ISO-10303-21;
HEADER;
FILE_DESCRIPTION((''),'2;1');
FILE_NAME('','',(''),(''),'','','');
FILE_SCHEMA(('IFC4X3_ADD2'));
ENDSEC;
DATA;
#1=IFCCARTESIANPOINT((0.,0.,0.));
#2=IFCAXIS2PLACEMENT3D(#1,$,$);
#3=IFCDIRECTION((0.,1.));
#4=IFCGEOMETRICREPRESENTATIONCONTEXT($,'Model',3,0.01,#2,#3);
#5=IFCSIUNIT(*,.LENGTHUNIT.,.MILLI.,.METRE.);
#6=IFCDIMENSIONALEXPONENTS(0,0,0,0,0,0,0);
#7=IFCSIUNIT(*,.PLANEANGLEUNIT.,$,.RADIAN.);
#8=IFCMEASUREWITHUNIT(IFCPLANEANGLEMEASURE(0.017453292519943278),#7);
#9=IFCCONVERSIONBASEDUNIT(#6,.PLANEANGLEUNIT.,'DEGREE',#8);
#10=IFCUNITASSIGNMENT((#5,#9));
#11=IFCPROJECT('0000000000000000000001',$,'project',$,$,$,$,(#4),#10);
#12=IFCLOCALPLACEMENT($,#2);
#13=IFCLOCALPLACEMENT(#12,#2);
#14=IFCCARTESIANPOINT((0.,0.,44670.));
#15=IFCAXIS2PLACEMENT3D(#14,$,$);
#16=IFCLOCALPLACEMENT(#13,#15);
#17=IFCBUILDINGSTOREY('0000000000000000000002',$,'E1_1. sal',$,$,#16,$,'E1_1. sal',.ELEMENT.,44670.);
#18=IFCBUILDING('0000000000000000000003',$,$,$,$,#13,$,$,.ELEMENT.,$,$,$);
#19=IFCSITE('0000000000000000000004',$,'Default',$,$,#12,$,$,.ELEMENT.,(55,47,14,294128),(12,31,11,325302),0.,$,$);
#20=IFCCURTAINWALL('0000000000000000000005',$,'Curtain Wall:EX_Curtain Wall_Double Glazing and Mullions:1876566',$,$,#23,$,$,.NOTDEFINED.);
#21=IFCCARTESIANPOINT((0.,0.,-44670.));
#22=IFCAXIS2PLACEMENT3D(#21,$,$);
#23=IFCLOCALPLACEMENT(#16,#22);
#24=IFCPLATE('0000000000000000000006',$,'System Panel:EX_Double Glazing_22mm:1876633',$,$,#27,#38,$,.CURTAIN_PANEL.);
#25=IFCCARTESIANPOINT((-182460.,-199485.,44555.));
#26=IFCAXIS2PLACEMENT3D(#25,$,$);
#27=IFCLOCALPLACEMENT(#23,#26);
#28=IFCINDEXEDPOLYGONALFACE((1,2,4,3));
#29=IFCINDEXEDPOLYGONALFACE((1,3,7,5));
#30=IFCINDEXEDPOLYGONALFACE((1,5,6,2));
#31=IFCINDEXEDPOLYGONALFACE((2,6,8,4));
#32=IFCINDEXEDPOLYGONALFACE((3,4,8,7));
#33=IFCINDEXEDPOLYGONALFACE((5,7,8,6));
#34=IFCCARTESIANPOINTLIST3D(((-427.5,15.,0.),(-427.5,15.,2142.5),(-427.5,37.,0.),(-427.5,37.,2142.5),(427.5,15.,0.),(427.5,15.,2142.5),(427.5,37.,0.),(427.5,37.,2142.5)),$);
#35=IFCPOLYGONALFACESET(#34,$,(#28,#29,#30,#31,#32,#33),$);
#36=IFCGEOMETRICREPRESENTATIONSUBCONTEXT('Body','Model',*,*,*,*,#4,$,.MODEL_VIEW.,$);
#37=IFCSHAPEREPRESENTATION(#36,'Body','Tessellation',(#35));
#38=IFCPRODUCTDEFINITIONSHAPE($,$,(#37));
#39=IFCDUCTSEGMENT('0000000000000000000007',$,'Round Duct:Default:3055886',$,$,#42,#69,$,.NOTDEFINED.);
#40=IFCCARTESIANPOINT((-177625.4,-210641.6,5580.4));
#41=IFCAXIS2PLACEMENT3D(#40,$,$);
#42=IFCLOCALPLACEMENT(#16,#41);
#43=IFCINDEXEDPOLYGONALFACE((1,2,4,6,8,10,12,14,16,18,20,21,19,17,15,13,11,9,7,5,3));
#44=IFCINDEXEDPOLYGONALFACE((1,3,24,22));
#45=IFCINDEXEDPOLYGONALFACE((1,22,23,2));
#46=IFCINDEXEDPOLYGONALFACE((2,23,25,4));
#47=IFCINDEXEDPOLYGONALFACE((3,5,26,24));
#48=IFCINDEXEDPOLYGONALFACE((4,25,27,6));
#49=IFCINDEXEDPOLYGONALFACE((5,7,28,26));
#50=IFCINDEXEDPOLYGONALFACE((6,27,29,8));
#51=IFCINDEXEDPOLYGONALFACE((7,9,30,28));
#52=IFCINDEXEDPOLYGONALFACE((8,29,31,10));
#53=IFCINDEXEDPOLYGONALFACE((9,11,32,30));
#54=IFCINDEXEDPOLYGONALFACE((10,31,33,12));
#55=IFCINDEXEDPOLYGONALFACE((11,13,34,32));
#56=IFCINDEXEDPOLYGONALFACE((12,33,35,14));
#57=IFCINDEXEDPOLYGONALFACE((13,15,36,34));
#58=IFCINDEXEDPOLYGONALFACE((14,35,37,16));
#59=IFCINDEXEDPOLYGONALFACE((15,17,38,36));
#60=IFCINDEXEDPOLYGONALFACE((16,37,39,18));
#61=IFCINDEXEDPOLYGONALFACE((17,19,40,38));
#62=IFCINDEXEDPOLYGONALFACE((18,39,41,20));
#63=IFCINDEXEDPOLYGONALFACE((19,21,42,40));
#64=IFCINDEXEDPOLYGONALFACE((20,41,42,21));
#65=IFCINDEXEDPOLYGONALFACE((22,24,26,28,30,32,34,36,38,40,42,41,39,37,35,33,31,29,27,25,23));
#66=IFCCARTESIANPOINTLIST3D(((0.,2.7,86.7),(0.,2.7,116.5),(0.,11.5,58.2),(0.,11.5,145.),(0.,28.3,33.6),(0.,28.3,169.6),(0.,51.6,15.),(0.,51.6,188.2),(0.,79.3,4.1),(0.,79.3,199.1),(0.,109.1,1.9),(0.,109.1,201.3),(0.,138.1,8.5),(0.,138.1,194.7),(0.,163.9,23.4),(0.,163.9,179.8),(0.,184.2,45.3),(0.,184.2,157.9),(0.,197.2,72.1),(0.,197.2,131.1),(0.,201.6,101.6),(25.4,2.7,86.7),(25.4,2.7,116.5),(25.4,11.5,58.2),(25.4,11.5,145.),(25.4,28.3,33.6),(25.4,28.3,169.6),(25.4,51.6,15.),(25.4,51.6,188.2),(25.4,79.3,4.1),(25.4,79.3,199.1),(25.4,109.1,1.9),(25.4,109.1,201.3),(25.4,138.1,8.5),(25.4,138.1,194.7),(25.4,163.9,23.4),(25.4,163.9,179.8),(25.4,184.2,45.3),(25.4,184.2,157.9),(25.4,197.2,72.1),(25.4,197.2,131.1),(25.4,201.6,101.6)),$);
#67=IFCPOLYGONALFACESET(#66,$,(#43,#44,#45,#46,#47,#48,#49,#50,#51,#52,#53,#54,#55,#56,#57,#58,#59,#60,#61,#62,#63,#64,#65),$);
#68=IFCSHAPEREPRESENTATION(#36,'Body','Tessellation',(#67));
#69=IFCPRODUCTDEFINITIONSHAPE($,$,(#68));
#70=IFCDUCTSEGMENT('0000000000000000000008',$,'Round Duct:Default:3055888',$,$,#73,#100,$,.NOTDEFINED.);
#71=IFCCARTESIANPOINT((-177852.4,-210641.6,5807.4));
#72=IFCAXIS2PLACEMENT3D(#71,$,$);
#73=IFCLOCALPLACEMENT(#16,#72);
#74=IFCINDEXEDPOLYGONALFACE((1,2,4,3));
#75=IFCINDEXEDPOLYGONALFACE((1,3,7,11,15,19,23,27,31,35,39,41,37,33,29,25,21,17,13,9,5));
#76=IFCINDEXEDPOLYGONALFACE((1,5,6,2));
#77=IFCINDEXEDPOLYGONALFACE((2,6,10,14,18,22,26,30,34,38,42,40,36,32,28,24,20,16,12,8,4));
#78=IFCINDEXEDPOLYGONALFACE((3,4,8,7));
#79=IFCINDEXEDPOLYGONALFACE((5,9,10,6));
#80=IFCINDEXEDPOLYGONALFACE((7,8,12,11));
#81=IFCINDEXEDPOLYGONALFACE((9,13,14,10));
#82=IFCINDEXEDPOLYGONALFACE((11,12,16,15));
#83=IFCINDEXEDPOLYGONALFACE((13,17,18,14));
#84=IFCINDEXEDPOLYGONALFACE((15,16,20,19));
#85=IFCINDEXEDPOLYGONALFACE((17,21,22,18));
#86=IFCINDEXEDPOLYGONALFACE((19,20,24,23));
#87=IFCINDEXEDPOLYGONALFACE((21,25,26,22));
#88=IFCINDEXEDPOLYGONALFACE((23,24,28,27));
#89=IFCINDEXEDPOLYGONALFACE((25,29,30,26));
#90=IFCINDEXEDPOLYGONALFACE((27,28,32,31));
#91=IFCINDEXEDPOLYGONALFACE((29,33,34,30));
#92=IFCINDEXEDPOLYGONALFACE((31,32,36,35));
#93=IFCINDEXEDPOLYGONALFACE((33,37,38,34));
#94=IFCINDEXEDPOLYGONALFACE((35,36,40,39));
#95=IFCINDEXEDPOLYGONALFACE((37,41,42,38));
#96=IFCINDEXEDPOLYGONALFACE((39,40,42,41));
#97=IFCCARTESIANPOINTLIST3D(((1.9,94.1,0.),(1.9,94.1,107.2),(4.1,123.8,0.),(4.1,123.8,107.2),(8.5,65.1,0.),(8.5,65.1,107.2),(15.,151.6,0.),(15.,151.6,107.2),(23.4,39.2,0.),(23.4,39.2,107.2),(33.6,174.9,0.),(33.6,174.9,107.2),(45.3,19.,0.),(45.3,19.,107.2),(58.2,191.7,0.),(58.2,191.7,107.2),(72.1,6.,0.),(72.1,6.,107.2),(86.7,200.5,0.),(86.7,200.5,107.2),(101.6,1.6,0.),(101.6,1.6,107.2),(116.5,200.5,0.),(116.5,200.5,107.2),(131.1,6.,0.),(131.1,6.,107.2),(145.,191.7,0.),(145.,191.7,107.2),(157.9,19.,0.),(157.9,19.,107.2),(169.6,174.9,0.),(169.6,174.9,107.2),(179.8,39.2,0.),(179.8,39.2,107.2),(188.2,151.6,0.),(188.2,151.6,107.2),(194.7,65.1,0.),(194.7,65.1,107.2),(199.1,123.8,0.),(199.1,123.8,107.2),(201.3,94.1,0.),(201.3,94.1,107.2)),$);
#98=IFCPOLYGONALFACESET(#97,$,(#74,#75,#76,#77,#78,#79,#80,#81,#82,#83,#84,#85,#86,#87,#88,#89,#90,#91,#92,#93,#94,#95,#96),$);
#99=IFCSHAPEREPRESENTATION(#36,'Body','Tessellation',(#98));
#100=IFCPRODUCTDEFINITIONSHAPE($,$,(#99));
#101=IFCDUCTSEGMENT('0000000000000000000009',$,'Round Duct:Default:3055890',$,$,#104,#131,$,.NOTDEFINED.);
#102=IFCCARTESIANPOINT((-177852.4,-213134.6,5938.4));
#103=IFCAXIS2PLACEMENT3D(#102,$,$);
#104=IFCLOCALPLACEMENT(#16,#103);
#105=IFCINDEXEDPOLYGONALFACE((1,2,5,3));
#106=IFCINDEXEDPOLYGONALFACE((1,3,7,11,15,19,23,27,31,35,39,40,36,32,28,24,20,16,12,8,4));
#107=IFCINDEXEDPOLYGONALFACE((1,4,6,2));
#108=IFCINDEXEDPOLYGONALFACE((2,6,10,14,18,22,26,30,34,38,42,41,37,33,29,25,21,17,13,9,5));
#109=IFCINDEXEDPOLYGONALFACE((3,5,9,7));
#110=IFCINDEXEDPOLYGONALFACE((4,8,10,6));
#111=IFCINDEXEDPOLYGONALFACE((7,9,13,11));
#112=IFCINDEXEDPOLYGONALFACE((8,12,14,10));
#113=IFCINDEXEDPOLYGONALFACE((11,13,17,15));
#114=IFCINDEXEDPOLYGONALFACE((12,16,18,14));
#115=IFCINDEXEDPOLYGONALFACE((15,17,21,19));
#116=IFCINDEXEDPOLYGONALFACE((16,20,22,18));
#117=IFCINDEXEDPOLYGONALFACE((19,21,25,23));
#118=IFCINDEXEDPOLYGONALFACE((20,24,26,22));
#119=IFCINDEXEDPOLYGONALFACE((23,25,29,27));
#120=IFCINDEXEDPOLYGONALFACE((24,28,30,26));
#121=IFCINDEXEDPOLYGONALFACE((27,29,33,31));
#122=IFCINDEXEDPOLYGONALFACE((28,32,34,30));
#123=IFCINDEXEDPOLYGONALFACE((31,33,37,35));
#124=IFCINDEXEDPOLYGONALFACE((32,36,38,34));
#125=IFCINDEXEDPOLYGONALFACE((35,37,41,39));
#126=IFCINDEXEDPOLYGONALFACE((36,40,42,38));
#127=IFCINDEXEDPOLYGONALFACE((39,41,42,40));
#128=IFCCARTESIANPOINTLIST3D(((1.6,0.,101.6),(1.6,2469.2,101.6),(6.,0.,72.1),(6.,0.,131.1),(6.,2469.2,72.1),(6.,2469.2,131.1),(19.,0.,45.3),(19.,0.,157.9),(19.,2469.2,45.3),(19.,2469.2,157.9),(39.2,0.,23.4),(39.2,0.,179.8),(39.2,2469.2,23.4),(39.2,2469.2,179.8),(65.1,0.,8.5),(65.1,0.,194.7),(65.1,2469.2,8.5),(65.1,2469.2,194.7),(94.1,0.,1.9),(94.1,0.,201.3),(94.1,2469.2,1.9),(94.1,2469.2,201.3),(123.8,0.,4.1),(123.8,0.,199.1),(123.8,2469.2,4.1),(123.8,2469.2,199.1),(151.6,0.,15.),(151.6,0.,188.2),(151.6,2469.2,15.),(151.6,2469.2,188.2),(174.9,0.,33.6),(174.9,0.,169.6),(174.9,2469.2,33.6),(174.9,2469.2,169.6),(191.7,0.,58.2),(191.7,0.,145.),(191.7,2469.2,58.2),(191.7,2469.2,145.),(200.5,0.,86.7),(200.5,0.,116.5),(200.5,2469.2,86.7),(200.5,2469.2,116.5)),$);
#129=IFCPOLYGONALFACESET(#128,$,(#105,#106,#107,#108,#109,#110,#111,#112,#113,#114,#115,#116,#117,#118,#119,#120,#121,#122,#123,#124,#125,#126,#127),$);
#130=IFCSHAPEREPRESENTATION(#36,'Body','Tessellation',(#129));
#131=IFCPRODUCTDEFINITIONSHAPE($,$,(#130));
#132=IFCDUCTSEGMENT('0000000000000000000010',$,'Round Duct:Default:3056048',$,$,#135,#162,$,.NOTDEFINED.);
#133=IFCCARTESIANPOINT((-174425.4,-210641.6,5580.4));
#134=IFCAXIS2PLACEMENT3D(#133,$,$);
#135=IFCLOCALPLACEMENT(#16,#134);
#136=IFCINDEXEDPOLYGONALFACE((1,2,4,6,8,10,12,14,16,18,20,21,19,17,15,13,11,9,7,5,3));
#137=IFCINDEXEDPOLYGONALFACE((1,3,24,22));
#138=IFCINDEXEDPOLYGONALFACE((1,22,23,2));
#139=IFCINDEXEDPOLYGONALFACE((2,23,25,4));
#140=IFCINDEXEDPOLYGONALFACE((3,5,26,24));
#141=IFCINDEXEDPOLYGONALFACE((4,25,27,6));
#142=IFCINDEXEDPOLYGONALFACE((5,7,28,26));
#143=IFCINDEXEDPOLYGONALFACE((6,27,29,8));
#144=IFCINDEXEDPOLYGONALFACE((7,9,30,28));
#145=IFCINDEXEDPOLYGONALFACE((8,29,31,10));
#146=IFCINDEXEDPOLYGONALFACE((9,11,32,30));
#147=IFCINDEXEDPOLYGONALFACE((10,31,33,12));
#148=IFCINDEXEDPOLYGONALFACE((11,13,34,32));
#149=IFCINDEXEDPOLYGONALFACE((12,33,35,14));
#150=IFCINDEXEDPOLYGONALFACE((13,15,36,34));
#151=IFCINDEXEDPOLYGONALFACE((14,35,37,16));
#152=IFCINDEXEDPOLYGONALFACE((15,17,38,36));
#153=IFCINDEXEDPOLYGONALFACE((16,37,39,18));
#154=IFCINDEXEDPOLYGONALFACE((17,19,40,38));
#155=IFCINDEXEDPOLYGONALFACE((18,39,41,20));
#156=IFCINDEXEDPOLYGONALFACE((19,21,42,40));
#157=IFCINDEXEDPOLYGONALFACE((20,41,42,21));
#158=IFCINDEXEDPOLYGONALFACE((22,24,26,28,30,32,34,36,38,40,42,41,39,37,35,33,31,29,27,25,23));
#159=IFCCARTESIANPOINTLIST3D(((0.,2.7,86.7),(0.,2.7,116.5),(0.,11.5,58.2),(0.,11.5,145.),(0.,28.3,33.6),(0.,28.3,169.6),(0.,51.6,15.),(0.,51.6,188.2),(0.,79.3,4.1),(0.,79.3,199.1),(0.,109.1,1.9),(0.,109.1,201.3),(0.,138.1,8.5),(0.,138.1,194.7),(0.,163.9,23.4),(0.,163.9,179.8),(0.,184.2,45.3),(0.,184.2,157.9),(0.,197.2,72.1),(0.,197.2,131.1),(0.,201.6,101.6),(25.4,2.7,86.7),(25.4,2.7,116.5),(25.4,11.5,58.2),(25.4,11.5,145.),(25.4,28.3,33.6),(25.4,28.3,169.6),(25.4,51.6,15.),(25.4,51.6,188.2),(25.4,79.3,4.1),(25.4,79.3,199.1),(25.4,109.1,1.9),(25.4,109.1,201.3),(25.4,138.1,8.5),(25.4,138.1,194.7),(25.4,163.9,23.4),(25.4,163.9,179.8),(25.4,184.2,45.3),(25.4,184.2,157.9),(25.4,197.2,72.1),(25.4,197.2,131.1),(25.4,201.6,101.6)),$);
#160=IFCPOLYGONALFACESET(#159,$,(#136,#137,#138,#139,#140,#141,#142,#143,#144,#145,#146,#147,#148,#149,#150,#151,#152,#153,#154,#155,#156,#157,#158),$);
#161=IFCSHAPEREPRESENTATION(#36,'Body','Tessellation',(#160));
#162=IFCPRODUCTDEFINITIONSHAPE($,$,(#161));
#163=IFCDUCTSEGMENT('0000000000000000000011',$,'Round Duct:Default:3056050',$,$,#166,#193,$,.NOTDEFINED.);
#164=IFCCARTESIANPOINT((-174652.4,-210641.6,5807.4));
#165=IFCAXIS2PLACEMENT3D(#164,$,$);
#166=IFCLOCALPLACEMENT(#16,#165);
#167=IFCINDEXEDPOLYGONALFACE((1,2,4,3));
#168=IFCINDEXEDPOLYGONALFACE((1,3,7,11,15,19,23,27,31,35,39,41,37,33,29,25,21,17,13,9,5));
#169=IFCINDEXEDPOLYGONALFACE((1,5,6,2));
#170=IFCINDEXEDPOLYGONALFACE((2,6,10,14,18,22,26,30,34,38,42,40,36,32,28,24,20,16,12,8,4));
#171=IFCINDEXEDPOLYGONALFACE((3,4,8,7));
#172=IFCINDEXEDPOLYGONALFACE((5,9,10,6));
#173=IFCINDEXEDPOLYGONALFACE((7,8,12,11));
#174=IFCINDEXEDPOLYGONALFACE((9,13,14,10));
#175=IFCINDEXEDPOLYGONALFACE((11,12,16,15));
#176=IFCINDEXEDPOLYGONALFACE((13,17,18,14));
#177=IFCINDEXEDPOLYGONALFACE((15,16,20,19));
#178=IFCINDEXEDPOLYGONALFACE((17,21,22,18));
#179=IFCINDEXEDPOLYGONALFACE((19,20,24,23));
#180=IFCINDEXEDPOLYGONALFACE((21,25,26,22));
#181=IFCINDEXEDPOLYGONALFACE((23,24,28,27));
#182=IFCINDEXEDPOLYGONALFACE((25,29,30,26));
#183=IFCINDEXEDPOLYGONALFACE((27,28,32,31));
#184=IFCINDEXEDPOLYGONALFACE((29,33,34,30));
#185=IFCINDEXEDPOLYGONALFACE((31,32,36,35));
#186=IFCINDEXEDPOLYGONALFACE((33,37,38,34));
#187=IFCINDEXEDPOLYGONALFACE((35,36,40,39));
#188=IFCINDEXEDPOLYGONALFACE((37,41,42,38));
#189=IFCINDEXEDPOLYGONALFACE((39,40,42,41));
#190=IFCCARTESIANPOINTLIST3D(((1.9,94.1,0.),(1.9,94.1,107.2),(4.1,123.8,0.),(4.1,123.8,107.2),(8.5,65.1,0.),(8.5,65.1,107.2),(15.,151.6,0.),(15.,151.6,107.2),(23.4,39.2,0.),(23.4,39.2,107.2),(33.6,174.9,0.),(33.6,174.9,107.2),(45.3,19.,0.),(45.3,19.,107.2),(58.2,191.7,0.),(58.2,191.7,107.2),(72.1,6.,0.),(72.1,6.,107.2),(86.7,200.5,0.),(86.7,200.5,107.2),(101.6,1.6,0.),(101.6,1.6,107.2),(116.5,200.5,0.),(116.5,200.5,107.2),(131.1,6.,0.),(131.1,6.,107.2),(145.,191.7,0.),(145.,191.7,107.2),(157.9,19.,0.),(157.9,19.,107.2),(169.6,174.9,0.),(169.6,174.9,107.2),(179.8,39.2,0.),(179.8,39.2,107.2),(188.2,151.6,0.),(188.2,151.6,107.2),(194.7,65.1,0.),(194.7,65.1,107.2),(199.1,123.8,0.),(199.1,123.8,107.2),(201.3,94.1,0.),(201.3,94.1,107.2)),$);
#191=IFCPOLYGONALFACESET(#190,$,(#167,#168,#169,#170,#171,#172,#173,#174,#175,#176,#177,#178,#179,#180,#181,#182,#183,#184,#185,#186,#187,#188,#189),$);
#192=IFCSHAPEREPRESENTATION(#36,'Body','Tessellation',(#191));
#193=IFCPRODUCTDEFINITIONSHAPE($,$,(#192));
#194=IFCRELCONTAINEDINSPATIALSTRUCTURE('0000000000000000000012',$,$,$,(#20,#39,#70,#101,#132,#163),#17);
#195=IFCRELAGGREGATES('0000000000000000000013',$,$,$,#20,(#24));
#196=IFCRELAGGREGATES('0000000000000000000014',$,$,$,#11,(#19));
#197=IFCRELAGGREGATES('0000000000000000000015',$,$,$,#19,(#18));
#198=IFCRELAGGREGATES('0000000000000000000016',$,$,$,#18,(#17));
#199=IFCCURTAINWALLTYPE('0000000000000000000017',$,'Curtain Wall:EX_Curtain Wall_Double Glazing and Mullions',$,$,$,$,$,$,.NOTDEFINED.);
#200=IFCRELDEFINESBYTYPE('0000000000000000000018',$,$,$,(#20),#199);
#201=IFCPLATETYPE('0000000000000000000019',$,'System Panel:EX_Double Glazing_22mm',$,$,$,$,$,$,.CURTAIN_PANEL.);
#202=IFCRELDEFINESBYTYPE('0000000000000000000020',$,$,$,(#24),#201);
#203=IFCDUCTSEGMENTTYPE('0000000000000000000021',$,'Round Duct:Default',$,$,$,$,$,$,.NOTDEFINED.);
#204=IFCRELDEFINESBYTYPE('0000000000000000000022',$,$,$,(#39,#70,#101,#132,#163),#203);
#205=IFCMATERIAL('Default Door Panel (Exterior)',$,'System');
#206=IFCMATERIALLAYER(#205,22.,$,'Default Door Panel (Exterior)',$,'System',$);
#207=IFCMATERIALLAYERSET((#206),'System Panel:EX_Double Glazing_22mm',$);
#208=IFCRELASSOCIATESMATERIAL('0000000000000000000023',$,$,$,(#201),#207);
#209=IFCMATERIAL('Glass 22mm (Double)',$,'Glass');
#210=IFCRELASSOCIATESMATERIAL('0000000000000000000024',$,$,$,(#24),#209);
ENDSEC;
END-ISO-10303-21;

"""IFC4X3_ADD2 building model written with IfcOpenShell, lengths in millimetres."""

from ifc_helpers import new_model, entity, si_unit, converted_unit, direction, frame, frame_2d, origin, origin_2d_with_axis, place, context, subcontext, project, spatial, rectangle, circle, extrude, source, transform, mapped, material, layer, layer_set, type_object, type_shapes, element, aggregate, save


model = new_model("IFC4X3_ADD2")

# Units and contexts
model_context = context("Model", 3, precision=0.01, world=origin(), true_north=direction((0.0, 1.0)))
body_context = subcontext(model_context, "Body", "Model", "MODEL_VIEW")
ifc_project = project(units=[si_unit("LENGTHUNIT", "METRE", prefix="MILLI"), converted_unit("PLANEANGLEUNIT", "DEGREE", entity("IfcPlaneAngleMeasure", 0.017453292519943278), si_unit("PLANEANGLEUNIT", "RADIAN"), dimensions=[0, 0, 0, 0, 0, 0, 0])], contexts=[model_context])

# Site, building, storey
site_placement = place(None, origin())
site = spatial("IfcSite", under=ifc_project, at=site_placement, Name="Default", CompositionType="ELEMENT", RefLatitude=(55, 47, 14, 294128), RefLongitude=(12, 31, 11, 325302), RefElevation=0.0)
building_placement = place(site_placement, origin())
building = spatial("IfcBuilding", under=site, at=building_placement, CompositionType="ELEMENT")
storey_placement = place(building_placement, frame((0.0, 0.0, 44670.0)))
storey = spatial("IfcBuildingStorey", under=building, at=storey_placement, Name="E1_1. sal", LongName="E1_1. sal", CompositionType="ELEMENT", Elevation=44670.0)

# Curtain wall, plate
curtain_wall_type = type_object("IfcCurtainWallType", Name="Curtain Wall:EX_Curtain Wall_Double Glazing and Mullions", PredefinedType="NOTDEFINED")
curtain_wall_placement = place(storey_placement, frame((0.0, 0.0, -44670.0)))
curtain_wall = element("IfcCurtainWall", 1, at=curtain_wall_placement, inside=storey, type_object=curtain_wall_type, Name="Curtain Wall:EX_Curtain Wall_Double Glazing and Mullions:1876566", PredefinedType="NOTDEFINED")
ifc_material_1 = material(Name="Glass 22mm (Double)", Category="Glass")
ifc_material_2 = material(Name="Default Door Panel (Exterior)", Category="System")
ifc_layer_1 = layer(ifc_material_2, 22.0, Name="Default Door Panel (Exterior)", Category="System")
ifc_layer_set_1 = layer_set([ifc_layer_1], Name="System Panel:EX_Double Glazing_22mm")
plate_type_1 = type_object("IfcPlateType", Name="System Panel:EX_Double Glazing_22mm", PredefinedType="CURTAIN_PANEL", material=ifc_layer_set_1)
shared_shape_1 = source(origin(), body_context, "Body", "SweptSolid", [
    extrude(rectangle(XDim=22.0, YDim=855.0, at=origin_2d_with_axis()), frame((0.0, 26.0, 0.0), z_axis=(0.0, 0.0, 1.0), x_axis=(0.0, 1.0, 0.0)), (0.0, 0.0, 1.0), 2142.5),
])
type_shapes(plate_type_1, [shared_shape_1])
plate_1_placement = place(curtain_wall_placement, frame((-182460.0, -199485.0, 44555.0)))
plate_1 = element("IfcPlate", 2, at=plate_1_placement, type_object=plate_type_1, material=ifc_material_1, Name="System Panel:EX_Double Glazing_22mm:1876633", PredefinedType="CURTAIN_PANEL", context=body_context, shape_type="MappedRepresentation", body=[
    mapped(shared_shape_1, transform((0.0, 0.0, 0.0), scale=1.0)),
])
aggregate(curtain_wall, [plate_1])

# Duct segments
duct_segment_type = type_object("IfcDuctSegmentType", Name="Round Duct:Default", PredefinedType="NOTDEFINED")
duct_segment_1_placement = place(storey_placement, frame((-177625.4, -210641.6, 5580.4)))
element("IfcDuctSegment", 3, at=duct_segment_1_placement, inside=storey, type_object=duct_segment_type, Name="Round Duct:Default:3055886", PredefinedType="NOTDEFINED", context=body_context, shape_type="SweptSolid", body=[
    extrude(circle(Radius=100.0, at=frame_2d((0.0, 0.0), x_axis=(1.0, 0.0))), frame((0.0, 101.6, 101.6), z_axis=(1.0, 0.0, 0.0), x_axis=(0.0, 1.0, 0.0)), (0.0, 0.0, 1.0), 25.4),
])
duct_segment_2_placement = place(storey_placement, frame((-177852.4, -210641.6, 5807.4)))
element("IfcDuctSegment", 4, at=duct_segment_2_placement, inside=storey, type_object=duct_segment_type, Name="Round Duct:Default:3055888", PredefinedType="NOTDEFINED", context=body_context, shape_type="SweptSolid", body=[
    extrude(circle(Radius=100.0, at=frame_2d((0.0, 0.0), x_axis=(1.0, 0.0))), frame((101.6, 101.6, 0.0), z_axis=(0.0, 0.0, 1.0), x_axis=(0.0, -1.0, 0.0)), (0.0, 0.0, 1.0), 107.2),
])
duct_segment_3_placement = place(storey_placement, frame((-177852.4, -213134.6, 5938.4)))
element("IfcDuctSegment", 5, at=duct_segment_3_placement, inside=storey, type_object=duct_segment_type, Name="Round Duct:Default:3055890", PredefinedType="NOTDEFINED", context=body_context, shape_type="SweptSolid", body=[
    extrude(circle(Radius=100.0, at=origin_2d_with_axis()), frame((101.6, 0.0, 101.6), z_axis=(0.0, 1.0, 0.0), x_axis=(-1.0, 0.0, 0.0)), (0.0, 0.0, 1.0), 2469.2),
])
duct_segment_4_placement = place(storey_placement, frame((-174425.4, -210641.6, 5580.4)))
element("IfcDuctSegment", 6, at=duct_segment_4_placement, inside=storey, type_object=duct_segment_type, Name="Round Duct:Default:3056048", PredefinedType="NOTDEFINED", context=body_context, shape_type="SweptSolid", body=[
    extrude(circle(Radius=100.0, at=frame_2d((0.0, 0.0), x_axis=(1.0, 0.0))), frame((0.0, 101.6, 101.6), z_axis=(1.0, 0.0, 0.0), x_axis=(0.0, 1.0, 0.0)), (0.0, 0.0, 1.0), 25.4),
])
duct_segment_5_placement = place(storey_placement, frame((-174652.4, -210641.6, 5807.4)))
element("IfcDuctSegment", 7, at=duct_segment_5_placement, inside=storey, type_object=duct_segment_type, Name="Round Duct:Default:3056050", PredefinedType="NOTDEFINED", context=body_context, shape_type="SweptSolid", body=[
    extrude(circle(Radius=100.0, at=frame_2d((0.0, 0.0), x_axis=(1.0, 0.0))), frame((101.6, 101.6, 0.0), z_axis=(0.0, 0.0, 1.0), x_axis=(0.0, -1.0, 0.0)), (0.0, 0.0, 1.0), 107.2),
])

save(model, "model.ifc")
